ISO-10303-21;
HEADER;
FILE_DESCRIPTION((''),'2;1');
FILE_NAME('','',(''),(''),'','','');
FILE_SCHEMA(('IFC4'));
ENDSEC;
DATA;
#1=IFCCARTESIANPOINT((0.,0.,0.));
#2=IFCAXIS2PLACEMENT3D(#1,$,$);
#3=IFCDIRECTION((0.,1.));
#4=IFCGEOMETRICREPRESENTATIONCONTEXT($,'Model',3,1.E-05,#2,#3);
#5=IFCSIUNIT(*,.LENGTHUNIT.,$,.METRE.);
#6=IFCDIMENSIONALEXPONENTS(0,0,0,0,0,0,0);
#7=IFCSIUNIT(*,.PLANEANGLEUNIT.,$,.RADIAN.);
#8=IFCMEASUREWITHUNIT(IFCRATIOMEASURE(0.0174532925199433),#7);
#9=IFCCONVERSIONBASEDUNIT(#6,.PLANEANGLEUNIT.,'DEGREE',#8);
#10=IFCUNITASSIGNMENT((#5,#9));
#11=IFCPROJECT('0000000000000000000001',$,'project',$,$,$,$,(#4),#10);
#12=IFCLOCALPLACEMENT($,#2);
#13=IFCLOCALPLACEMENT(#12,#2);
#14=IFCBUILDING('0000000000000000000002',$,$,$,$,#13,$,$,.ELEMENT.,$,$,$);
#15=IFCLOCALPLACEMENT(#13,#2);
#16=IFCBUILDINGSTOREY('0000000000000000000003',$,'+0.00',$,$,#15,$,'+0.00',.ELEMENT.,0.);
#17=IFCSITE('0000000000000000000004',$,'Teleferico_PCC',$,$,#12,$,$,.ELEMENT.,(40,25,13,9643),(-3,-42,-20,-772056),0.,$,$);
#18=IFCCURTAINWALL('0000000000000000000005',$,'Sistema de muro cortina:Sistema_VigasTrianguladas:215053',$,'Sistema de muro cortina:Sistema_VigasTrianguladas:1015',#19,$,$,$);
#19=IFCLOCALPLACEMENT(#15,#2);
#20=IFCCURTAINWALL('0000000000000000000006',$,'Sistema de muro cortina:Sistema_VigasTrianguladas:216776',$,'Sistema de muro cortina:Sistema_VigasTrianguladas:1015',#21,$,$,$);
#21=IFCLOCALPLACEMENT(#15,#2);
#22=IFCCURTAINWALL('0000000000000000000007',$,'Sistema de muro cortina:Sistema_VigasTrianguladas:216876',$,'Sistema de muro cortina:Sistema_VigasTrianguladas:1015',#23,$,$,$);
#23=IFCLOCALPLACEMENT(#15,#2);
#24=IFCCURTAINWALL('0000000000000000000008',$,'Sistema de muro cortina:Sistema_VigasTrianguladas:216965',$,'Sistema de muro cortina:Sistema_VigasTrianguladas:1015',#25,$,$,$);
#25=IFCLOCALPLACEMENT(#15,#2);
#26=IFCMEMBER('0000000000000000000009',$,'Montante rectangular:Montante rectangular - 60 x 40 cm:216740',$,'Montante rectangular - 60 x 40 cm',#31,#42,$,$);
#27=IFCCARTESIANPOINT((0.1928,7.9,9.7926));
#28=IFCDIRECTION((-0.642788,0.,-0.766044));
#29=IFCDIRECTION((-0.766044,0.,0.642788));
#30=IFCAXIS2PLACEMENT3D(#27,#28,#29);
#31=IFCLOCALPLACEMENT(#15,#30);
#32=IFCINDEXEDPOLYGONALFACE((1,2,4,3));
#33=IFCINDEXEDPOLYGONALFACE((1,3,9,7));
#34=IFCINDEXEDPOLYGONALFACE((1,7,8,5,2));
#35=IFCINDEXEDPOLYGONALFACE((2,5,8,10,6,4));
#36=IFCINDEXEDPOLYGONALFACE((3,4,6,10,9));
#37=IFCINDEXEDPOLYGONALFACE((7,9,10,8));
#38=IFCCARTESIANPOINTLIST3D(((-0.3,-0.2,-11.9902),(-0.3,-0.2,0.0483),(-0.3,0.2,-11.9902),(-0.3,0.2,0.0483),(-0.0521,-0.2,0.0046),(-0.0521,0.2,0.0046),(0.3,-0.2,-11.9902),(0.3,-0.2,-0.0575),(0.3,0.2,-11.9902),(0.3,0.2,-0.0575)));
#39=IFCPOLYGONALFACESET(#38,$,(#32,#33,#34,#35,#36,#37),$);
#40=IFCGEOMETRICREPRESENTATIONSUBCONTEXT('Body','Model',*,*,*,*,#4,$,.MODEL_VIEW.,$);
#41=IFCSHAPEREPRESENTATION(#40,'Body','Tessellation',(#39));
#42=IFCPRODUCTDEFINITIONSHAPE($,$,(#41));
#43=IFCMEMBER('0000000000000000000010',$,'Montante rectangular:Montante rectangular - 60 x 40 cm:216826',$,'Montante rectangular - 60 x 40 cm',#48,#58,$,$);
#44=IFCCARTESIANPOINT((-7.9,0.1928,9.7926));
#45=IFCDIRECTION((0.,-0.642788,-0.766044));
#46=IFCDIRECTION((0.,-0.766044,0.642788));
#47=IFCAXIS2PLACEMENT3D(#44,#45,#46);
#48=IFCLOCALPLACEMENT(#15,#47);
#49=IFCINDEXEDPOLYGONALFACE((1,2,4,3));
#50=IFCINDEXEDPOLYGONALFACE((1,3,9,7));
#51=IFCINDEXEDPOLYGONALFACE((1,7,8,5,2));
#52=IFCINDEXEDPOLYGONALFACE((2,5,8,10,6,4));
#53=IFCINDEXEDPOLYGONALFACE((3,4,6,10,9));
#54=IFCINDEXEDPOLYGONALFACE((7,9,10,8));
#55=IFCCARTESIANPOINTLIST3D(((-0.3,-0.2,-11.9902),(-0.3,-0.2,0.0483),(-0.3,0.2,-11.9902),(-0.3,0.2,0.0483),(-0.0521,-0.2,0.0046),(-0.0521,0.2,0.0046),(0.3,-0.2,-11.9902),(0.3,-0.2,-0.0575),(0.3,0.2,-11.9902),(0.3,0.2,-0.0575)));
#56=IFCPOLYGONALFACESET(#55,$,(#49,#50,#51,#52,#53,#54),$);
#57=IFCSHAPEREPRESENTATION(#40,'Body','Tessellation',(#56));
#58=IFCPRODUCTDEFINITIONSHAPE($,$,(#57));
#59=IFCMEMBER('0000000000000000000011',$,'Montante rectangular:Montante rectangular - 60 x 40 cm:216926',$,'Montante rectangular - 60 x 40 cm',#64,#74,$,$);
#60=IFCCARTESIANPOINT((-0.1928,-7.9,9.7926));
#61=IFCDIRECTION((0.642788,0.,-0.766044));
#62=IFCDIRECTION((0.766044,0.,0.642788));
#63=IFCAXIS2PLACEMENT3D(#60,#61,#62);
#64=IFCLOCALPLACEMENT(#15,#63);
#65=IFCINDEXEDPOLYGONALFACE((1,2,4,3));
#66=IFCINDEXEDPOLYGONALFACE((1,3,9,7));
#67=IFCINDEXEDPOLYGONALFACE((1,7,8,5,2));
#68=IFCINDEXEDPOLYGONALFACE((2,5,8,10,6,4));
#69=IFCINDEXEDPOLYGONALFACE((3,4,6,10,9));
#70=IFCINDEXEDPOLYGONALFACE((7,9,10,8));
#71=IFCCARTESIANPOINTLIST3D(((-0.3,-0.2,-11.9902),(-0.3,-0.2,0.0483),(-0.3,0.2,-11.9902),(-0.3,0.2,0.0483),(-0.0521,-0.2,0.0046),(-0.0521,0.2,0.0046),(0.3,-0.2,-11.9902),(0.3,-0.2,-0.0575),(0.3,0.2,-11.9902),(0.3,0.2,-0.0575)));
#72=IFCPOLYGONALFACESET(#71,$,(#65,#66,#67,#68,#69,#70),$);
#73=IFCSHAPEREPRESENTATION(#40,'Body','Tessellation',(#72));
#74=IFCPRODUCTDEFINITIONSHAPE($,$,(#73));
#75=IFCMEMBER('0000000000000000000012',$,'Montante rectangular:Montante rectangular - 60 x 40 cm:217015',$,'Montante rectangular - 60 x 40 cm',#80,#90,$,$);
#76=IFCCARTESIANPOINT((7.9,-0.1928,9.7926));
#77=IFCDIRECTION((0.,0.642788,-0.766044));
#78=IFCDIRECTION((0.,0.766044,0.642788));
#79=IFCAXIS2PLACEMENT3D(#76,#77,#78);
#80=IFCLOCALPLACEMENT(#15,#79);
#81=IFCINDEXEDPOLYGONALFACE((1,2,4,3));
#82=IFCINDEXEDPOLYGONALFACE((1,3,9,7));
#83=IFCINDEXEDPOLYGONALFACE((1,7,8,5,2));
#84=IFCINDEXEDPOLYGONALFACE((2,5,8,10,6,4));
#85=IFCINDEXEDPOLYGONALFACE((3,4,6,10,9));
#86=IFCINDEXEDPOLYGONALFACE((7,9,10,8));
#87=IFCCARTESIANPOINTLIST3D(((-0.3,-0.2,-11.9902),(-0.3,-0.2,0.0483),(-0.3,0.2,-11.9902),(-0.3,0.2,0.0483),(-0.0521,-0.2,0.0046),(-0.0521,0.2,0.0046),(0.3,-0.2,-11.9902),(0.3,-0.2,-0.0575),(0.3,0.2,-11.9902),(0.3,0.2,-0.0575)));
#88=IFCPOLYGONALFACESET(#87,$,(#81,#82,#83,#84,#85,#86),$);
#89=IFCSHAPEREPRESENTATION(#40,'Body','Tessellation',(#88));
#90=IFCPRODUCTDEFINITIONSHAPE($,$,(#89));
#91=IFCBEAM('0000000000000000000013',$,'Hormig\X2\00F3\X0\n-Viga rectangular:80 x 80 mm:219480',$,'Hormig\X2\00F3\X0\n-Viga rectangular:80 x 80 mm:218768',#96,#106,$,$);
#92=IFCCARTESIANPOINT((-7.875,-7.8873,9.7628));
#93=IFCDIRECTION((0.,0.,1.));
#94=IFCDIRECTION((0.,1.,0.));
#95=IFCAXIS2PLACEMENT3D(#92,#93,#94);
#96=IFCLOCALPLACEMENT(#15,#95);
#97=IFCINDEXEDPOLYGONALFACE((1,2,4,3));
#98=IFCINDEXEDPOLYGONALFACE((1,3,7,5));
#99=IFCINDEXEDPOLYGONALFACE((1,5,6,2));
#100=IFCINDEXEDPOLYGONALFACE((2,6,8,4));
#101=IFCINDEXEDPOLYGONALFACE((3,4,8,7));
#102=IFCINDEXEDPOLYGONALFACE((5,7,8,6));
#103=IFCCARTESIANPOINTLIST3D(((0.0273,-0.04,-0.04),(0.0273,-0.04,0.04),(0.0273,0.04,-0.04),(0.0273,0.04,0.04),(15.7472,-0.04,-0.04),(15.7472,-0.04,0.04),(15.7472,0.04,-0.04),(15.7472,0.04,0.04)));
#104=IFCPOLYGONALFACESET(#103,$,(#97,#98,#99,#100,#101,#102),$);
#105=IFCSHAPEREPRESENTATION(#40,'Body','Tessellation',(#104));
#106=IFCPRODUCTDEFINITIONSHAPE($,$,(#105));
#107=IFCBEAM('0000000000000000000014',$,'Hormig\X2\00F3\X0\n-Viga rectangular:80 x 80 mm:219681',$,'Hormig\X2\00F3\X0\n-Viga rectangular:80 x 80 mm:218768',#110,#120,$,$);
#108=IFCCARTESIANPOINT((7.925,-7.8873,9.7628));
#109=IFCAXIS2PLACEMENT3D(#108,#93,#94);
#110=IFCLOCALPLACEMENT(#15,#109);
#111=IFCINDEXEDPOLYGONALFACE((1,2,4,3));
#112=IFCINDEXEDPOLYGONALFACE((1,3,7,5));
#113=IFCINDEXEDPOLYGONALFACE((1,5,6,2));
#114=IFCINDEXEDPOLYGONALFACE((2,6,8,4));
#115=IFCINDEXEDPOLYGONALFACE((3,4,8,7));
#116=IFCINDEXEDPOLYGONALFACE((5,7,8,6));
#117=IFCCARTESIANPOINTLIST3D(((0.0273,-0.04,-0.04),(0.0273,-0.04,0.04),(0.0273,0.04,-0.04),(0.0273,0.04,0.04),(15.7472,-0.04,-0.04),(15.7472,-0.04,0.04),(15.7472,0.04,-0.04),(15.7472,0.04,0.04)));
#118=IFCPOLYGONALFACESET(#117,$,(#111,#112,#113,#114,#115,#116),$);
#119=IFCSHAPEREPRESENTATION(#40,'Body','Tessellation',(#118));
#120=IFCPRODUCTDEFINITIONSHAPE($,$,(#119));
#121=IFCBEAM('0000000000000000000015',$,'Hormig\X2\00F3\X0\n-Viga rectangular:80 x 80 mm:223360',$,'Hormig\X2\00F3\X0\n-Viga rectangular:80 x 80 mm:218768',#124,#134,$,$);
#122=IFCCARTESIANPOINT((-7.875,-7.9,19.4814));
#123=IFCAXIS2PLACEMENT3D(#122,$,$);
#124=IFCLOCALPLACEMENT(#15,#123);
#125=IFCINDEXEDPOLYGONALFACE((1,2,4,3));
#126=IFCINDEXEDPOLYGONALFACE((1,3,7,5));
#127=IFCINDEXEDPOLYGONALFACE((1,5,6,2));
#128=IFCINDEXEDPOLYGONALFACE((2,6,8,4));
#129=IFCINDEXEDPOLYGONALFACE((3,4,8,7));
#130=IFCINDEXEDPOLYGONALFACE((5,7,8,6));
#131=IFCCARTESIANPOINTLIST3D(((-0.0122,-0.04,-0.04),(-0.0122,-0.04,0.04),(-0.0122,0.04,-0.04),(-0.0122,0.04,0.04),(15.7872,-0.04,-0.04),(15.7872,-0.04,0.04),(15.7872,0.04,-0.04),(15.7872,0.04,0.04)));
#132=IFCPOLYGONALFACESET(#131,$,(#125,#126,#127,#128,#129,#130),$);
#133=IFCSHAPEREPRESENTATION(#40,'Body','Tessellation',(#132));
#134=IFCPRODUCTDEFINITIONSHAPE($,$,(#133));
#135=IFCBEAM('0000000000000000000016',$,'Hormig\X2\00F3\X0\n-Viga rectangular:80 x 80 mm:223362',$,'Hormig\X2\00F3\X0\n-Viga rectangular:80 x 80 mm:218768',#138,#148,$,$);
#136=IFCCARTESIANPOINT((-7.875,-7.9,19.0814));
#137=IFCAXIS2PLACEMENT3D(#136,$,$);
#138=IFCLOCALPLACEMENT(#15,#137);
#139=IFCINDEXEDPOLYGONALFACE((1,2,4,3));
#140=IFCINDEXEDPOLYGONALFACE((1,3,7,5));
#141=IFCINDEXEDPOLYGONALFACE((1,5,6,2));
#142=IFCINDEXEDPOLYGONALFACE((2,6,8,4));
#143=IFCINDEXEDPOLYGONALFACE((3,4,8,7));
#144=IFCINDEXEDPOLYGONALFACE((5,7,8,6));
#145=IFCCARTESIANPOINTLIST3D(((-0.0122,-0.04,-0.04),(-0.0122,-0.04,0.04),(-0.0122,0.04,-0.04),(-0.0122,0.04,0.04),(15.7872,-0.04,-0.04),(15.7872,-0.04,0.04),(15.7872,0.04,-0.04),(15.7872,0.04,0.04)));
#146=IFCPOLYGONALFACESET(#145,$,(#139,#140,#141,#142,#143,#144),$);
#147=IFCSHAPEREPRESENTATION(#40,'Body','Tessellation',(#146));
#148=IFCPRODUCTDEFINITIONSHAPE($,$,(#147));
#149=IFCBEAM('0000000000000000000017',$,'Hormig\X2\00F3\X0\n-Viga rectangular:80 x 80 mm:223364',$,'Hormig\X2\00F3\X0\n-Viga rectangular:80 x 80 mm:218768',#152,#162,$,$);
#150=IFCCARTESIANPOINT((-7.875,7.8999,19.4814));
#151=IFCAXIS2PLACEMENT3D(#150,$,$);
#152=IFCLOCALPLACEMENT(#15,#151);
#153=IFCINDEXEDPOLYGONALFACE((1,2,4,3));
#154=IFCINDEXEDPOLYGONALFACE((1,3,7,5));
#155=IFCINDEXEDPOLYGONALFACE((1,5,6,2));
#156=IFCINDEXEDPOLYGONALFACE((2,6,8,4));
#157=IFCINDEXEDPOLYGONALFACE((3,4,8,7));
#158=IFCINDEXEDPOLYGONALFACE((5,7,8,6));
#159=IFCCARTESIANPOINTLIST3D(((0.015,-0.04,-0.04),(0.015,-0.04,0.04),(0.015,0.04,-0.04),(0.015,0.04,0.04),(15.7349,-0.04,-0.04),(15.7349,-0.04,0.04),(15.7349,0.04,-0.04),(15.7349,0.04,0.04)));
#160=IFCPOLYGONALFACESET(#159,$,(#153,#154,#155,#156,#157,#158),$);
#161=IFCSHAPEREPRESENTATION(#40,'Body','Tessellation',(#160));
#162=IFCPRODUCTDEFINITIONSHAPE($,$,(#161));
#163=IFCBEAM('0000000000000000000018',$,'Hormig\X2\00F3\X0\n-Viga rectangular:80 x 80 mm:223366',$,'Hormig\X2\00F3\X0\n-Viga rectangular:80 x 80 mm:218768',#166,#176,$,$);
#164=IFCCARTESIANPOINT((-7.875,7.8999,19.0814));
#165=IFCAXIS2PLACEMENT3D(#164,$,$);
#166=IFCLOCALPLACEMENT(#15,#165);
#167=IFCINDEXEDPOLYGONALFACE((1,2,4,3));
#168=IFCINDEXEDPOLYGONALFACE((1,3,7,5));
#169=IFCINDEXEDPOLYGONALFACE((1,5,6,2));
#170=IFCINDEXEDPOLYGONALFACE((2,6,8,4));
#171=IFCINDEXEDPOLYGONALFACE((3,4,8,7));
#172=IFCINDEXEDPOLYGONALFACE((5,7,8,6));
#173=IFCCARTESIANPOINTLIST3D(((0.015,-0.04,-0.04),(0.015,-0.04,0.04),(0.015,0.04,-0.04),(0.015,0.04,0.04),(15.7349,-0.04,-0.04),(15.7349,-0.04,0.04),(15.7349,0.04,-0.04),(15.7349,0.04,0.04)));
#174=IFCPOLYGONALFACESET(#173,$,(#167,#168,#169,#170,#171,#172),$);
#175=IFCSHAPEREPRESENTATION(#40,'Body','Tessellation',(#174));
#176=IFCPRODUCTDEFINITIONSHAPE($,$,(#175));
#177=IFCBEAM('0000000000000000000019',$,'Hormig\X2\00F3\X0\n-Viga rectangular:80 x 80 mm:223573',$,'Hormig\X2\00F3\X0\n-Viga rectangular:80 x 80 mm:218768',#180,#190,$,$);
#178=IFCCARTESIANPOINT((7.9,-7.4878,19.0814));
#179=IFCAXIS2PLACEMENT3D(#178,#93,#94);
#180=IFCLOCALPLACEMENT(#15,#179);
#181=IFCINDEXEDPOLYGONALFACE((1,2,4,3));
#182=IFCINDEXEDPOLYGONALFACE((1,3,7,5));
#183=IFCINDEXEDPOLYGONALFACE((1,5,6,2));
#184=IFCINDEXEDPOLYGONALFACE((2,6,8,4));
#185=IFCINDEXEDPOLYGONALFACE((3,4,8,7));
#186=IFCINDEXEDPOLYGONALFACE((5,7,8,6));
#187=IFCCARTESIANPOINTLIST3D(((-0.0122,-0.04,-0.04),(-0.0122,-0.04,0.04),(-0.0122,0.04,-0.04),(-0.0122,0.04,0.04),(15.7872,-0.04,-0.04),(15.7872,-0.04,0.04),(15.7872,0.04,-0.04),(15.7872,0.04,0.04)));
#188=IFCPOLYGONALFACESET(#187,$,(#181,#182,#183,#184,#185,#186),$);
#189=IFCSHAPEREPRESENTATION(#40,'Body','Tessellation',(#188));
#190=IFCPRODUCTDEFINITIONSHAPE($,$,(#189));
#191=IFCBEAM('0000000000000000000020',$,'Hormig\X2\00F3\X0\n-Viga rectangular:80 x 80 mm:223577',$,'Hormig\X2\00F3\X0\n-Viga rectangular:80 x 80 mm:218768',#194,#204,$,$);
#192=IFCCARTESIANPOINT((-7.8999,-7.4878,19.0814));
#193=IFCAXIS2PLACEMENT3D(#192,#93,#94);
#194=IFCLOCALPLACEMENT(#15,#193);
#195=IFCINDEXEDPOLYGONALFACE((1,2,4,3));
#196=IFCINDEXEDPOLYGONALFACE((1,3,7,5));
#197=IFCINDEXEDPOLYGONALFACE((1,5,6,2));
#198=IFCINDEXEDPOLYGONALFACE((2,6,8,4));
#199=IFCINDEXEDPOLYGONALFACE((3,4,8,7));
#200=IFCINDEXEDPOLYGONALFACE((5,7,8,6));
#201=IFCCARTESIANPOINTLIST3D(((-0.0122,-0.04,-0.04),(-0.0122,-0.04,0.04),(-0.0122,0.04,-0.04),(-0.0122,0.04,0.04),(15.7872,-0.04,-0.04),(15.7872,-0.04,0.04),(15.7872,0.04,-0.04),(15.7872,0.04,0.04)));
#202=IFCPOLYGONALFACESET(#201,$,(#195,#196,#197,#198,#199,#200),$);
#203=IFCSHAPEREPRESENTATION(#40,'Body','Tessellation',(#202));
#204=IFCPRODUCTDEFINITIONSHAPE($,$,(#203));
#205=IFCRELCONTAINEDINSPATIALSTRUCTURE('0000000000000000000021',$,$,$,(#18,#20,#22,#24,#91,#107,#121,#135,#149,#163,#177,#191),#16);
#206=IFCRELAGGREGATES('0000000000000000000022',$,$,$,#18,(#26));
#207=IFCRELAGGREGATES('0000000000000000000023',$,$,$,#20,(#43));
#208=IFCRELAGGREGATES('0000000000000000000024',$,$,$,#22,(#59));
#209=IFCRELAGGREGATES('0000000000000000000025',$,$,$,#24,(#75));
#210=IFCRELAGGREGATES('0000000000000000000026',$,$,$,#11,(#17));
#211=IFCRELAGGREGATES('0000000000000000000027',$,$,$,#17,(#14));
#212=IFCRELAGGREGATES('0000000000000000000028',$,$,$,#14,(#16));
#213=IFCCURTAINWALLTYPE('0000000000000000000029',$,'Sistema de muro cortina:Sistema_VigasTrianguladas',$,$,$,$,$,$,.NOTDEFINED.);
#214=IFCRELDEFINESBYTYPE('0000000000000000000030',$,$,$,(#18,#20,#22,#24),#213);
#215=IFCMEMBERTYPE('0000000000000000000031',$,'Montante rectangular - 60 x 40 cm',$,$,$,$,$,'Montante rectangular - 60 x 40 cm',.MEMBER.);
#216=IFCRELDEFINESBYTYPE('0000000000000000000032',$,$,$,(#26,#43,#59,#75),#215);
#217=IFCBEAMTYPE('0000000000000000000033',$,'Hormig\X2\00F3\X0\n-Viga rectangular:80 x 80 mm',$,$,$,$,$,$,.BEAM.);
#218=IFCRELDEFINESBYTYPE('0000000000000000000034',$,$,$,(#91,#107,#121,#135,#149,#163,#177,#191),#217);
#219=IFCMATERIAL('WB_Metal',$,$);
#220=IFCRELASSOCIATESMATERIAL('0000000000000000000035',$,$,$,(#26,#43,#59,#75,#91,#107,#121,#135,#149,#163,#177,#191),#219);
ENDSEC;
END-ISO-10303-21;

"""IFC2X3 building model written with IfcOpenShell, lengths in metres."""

from ifc_helpers import new_model, entity, si_unit, converted_unit, direction, frame, frame_2d, origin, origin_2d_with_axis, place, context, subcontext, project, spatial, polyline, rectangle, extrude, clip, bounded_halfspace, source, transform, mapped, material, type_object, type_shapes, element, aggregate, save


model = new_model("IFC2X3")

# Units and contexts
model_context = context("Model", 3, precision=1e-05, world=origin(), true_north=direction((0.0, 1.0)))
body_context = subcontext(model_context, "Body", "Model", "MODEL_VIEW")
ifc_project = project(units=[si_unit("LENGTHUNIT", "METRE"), converted_unit("PLANEANGLEUNIT", "DEGREE", entity("IfcRatioMeasure", 0.0174532925199433), si_unit("PLANEANGLEUNIT", "RADIAN"), dimensions=[0, 0, 0, 0, 0, 0, 0])], contexts=[model_context])

# Site, building, storey
site_placement = place(None, origin())
site = spatial("IfcSite", under=ifc_project, at=site_placement, Name="Teleferico_PCC", CompositionType="ELEMENT", RefLatitude=(40, 25, 13, 9643), RefLongitude=(-3, -42, -20, -772056), RefElevation=0.0)
building_placement = place(site_placement, origin())
building = spatial("IfcBuilding", under=site, at=building_placement, CompositionType="ELEMENT")
storey_placement = place(building_placement, origin())
storey = spatial("IfcBuildingStorey", under=building, at=storey_placement, Name="+0.00", LongName="+0.00", CompositionType="ELEMENT", Elevation=0.0)

# Curtain walls
curtain_wall_type = type_object("IfcCurtainWallType", Name="Sistema de muro cortina:Sistema_VigasTrianguladas", PredefinedType="NOTDEFINED")
curtain_wall_1_placement = place(storey_placement, origin())
curtain_wall_1 = element("IfcCurtainWall", 1, at=curtain_wall_1_placement, inside=storey, type_object=curtain_wall_type, Name="Sistema de muro cortina:Sistema_VigasTrianguladas:215053", ObjectType="Sistema de muro cortina:Sistema_VigasTrianguladas:1015")
ifc_material = material(Name="WB_Metal")
curtain_wall_2_placement = place(storey_placement, origin())
curtain_wall_2 = element("IfcCurtainWall", 2, at=curtain_wall_2_placement, inside=storey, type_object=curtain_wall_type, Name="Sistema de muro cortina:Sistema_VigasTrianguladas:216776", ObjectType="Sistema de muro cortina:Sistema_VigasTrianguladas:1015")
curtain_wall_3_placement = place(storey_placement, origin())
curtain_wall_3 = element("IfcCurtainWall", 3, at=curtain_wall_3_placement, inside=storey, type_object=curtain_wall_type, Name="Sistema de muro cortina:Sistema_VigasTrianguladas:216876", ObjectType="Sistema de muro cortina:Sistema_VigasTrianguladas:1015")

# Curtain wall
curtain_wall_4_placement = place(storey_placement, origin())
curtain_wall_4 = element("IfcCurtainWall", 4, at=curtain_wall_4_placement, inside=storey, type_object=curtain_wall_type, Name="Sistema de muro cortina:Sistema_VigasTrianguladas:216965", ObjectType="Sistema de muro cortina:Sistema_VigasTrianguladas:1015")

# Members
member_type_1 = type_object("IfcMemberType", Name="Montante rectangular - 60 x 40 cm", ElementType="Montante rectangular - 60 x 40 cm", PredefinedType="MEMBER")
shared_shape_1 = source(origin(), body_context, "Body", "Clipping", [
    clip(clip(extrude(rectangle(XDim=0.4, YDim=0.6, at=origin_2d_with_axis()), frame((0.0, 0.0, -11.9902), z_axis=(0.0, 0.0, 1.0), x_axis=(0.0, -1.0, 0.0)), (0.0, 0.0, 1.0), 12.0385), bounded_halfspace(frame((12.0514, -91.44, -2.1296), z_axis=(0.173648, 0.0, 0.984808), x_axis=(-0.984808, 0.0, 0.173648)), False, frame((0.0, 0.0, -11.9902), z_axis=(0.0, 0.0, 1.0), x_axis=(0.0, -1.0, 0.0)), polyline([(0.2, 0.3), (-0.2, 0.3), (-0.2, -0.0521), (0.2, -0.0521), (0.2, 0.3)]))), bounded_halfspace(frame((-0.0521, -91.44, 0.0046), z_axis=(0.173648, 0.0, 0.984808), x_axis=(-0.984808, 0.0, 0.173648)), False, frame((0.0, 0.0, -11.9902), z_axis=(0.0, 0.0, 1.0), x_axis=(0.0, -1.0, 0.0)), polyline([(-0.2, -0.0521), (-0.2, -0.3), (0.2, -0.3), (0.2, -0.0521), (-0.2, -0.0521)]))),
])
type_shapes(member_type_1, [shared_shape_1])
member_1_placement = place(storey_placement, frame((0.1928, 7.9, 9.7926), z_axis=(-0.642788, 0.0, -0.766044), x_axis=(-0.766044, 0.0, 0.642788)))
member_1 = element("IfcMember", 5, at=member_1_placement, type_object=member_type_1, material=ifc_material, Name="Montante rectangular:Montante rectangular - 60 x 40 cm:216740", ObjectType="Montante rectangular - 60 x 40 cm", context=body_context, shape_type="MappedRepresentation", body=[
    mapped(shared_shape_1, transform((0.0, 0.0, 0.0), scale=1.0)),
])
aggregate(curtain_wall_1, [member_1])
member_2_placement = place(storey_placement, frame((-7.9, 0.1928, 9.7926), z_axis=(0.0, -0.642788, -0.766044), x_axis=(0.0, -0.766044, 0.642788)))
member_2 = element("IfcMember", 6, at=member_2_placement, type_object=member_type_1, material=ifc_material, Name="Montante rectangular:Montante rectangular - 60 x 40 cm:216826", ObjectType="Montante rectangular - 60 x 40 cm", context=body_context, shape_type="MappedRepresentation", body=[
    mapped(shared_shape_1, transform((0.0, 0.0, 0.0), scale=1.0)),
])
aggregate(curtain_wall_2, [member_2])
member_3_placement = place(storey_placement, frame((-0.1928, -7.9, 9.7926), z_axis=(0.642788, 0.0, -0.766044), x_axis=(0.766044, 0.0, 0.642788)))
member_3 = element("IfcMember", 7, at=member_3_placement, type_object=member_type_1, material=ifc_material, Name="Montante rectangular:Montante rectangular - 60 x 40 cm:216926", ObjectType="Montante rectangular - 60 x 40 cm", context=body_context, shape_type="MappedRepresentation", body=[
    mapped(shared_shape_1, transform((0.0, 0.0, 0.0), scale=1.0)),
])
aggregate(curtain_wall_3, [member_3])
member_4_placement = place(storey_placement, frame((7.9, -0.1928, 9.7926), z_axis=(0.0, 0.642788, -0.766044), x_axis=(0.0, 0.766044, 0.642788)))
member_4 = element("IfcMember", 8, at=member_4_placement, type_object=member_type_1, material=ifc_material, Name="Montante rectangular:Montante rectangular - 60 x 40 cm:217015", ObjectType="Montante rectangular - 60 x 40 cm", context=body_context, shape_type="MappedRepresentation", body=[
    mapped(shared_shape_1, transform((0.0, 0.0, 0.0), scale=1.0)),
])
aggregate(curtain_wall_4, [member_4])

# Beams
beam_type = type_object("IfcBeamType", Name="Hormigón-Viga rectangular:80 x 80 mm", PredefinedType="BEAM")
beam_1_placement = place(storey_placement, frame((-7.875, -7.8873, 9.7628), z_axis=(0.0, 0.0, 1.0), x_axis=(0.0, 1.0, 0.0)))
element("IfcBeam", 9, at=beam_1_placement, inside=storey, type_object=beam_type, material=ifc_material, Name="Hormigón-Viga rectangular:80 x 80 mm:219480", ObjectType="Hormigón-Viga rectangular:80 x 80 mm:218768", context=body_context, shape_type="SweptSolid", body=[
    extrude(rectangle(XDim=0.08, YDim=0.08, at=frame_2d((0.0, 0.0), x_axis=(1.0, 0.0))), frame((0.0273, 0.0, 0.0), z_axis=(1.0, 0.0, 0.0), x_axis=(0.0, 0.0, -1.0)), (0.0, 0.0, 1.0), 15.7199),
])
beam_2_placement = place(storey_placement, frame((7.925, -7.8873, 9.7628), z_axis=(0.0, 0.0, 1.0), x_axis=(0.0, 1.0, 0.0)))
element("IfcBeam", 10, at=beam_2_placement, inside=storey, type_object=beam_type, material=ifc_material, Name="Hormigón-Viga rectangular:80 x 80 mm:219681", ObjectType="Hormigón-Viga rectangular:80 x 80 mm:218768", context=body_context, shape_type="SweptSolid", body=[
    extrude(rectangle(XDim=0.08, YDim=0.08, at=frame_2d((0.0, 0.0), x_axis=(1.0, 0.0))), frame((0.0273, 0.0, 0.0), z_axis=(1.0, 0.0, 0.0), x_axis=(0.0, 0.0, -1.0)), (0.0, 0.0, 1.0), 15.7199),
])
beam_3_placement = place(storey_placement, frame((-7.875, -7.9, 19.4814)))
element("IfcBeam", 11, at=beam_3_placement, inside=storey, type_object=beam_type, material=ifc_material, Name="Hormigón-Viga rectangular:80 x 80 mm:223360", ObjectType="Hormigón-Viga rectangular:80 x 80 mm:218768", context=body_context, shape_type="SweptSolid", body=[
    extrude(rectangle(XDim=0.08, YDim=0.08, at=frame_2d((0.0, 0.0), x_axis=(1.0, 0.0))), frame((-0.0122, 0.0, 0.0), z_axis=(1.0, 0.0, 0.0), x_axis=(0.0, 0.0, -1.0)), (0.0, 0.0, 1.0), 15.7994),
])
beam_4_placement = place(storey_placement, frame((-7.875, -7.9, 19.0814)))
element("IfcBeam", 12, at=beam_4_placement, inside=storey, type_object=beam_type, material=ifc_material, Name="Hormigón-Viga rectangular:80 x 80 mm:223362", ObjectType="Hormigón-Viga rectangular:80 x 80 mm:218768", context=body_context, shape_type="SweptSolid", body=[
    extrude(rectangle(XDim=0.08, YDim=0.08, at=frame_2d((0.0, 0.0), x_axis=(1.0, 0.0))), frame((-0.0122, 0.0, 0.0), z_axis=(1.0, 0.0, 0.0), x_axis=(0.0, 0.0, -1.0)), (0.0, 0.0, 1.0), 15.7994),
])
beam_5_placement = place(storey_placement, frame((-7.875, 7.8999, 19.4814)))
element("IfcBeam", 13, at=beam_5_placement, inside=storey, type_object=beam_type, material=ifc_material, Name="Hormigón-Viga rectangular:80 x 80 mm:223364", ObjectType="Hormigón-Viga rectangular:80 x 80 mm:218768", context=body_context, shape_type="SweptSolid", body=[
    extrude(rectangle(XDim=0.08, YDim=0.08, at=frame_2d((0.0, 0.0), x_axis=(1.0, 0.0))), frame((0.015, 0.0, 0.0), z_axis=(1.0, 0.0, 0.0), x_axis=(0.0, 0.0, -1.0)), (0.0, 0.0, 1.0), 15.7199),
])
beam_6_placement = place(storey_placement, frame((-7.875, 7.8999, 19.0814)))
element("IfcBeam", 14, at=beam_6_placement, inside=storey, type_object=beam_type, material=ifc_material, Name="Hormigón-Viga rectangular:80 x 80 mm:223366", ObjectType="Hormigón-Viga rectangular:80 x 80 mm:218768", context=body_context, shape_type="SweptSolid", body=[
    extrude(rectangle(XDim=0.08, YDim=0.08, at=frame_2d((0.0, 0.0), x_axis=(1.0, 0.0))), frame((0.015, 0.0, 0.0), z_axis=(1.0, 0.0, 0.0), x_axis=(0.0, 0.0, -1.0)), (0.0, 0.0, 1.0), 15.7199),
])
beam_7_placement = place(storey_placement, frame((7.9, -7.4878, 19.0814), z_axis=(0.0, 0.0, 1.0), x_axis=(0.0, 1.0, 0.0)))
element("IfcBeam", 15, at=beam_7_placement, inside=storey, type_object=beam_type, material=ifc_material, Name="Hormigón-Viga rectangular:80 x 80 mm:223573", ObjectType="Hormigón-Viga rectangular:80 x 80 mm:218768", context=body_context, shape_type="SweptSolid", body=[
    extrude(rectangle(XDim=0.08, YDim=0.08, at=frame_2d((0.0, 0.0), x_axis=(1.0, 0.0))), frame((-0.0122, 0.0, 0.0), z_axis=(1.0, 0.0, 0.0), x_axis=(0.0, 0.0, -1.0)), (0.0, 0.0, 1.0), 15.7994),
])
beam_8_placement = place(storey_placement, frame((-7.8999, -7.4878, 19.0814), z_axis=(0.0, 0.0, 1.0), x_axis=(0.0, 1.0, 0.0)))
element("IfcBeam", 16, at=beam_8_placement, inside=storey, type_object=beam_type, material=ifc_material, Name="Hormigón-Viga rectangular:80 x 80 mm:223577", ObjectType="Hormigón-Viga rectangular:80 x 80 mm:218768", context=body_context, shape_type="SweptSolid", body=[
    extrude(rectangle(XDim=0.08, YDim=0.08, at=frame_2d((0.0, 0.0), x_axis=(1.0, 0.0))), frame((-0.0122, 0.0, 0.0), z_axis=(1.0, 0.0, 0.0), x_axis=(0.0, 0.0, -1.0)), (0.0, 0.0, 1.0), 15.7994),
])

save(model, "model.ifc")
